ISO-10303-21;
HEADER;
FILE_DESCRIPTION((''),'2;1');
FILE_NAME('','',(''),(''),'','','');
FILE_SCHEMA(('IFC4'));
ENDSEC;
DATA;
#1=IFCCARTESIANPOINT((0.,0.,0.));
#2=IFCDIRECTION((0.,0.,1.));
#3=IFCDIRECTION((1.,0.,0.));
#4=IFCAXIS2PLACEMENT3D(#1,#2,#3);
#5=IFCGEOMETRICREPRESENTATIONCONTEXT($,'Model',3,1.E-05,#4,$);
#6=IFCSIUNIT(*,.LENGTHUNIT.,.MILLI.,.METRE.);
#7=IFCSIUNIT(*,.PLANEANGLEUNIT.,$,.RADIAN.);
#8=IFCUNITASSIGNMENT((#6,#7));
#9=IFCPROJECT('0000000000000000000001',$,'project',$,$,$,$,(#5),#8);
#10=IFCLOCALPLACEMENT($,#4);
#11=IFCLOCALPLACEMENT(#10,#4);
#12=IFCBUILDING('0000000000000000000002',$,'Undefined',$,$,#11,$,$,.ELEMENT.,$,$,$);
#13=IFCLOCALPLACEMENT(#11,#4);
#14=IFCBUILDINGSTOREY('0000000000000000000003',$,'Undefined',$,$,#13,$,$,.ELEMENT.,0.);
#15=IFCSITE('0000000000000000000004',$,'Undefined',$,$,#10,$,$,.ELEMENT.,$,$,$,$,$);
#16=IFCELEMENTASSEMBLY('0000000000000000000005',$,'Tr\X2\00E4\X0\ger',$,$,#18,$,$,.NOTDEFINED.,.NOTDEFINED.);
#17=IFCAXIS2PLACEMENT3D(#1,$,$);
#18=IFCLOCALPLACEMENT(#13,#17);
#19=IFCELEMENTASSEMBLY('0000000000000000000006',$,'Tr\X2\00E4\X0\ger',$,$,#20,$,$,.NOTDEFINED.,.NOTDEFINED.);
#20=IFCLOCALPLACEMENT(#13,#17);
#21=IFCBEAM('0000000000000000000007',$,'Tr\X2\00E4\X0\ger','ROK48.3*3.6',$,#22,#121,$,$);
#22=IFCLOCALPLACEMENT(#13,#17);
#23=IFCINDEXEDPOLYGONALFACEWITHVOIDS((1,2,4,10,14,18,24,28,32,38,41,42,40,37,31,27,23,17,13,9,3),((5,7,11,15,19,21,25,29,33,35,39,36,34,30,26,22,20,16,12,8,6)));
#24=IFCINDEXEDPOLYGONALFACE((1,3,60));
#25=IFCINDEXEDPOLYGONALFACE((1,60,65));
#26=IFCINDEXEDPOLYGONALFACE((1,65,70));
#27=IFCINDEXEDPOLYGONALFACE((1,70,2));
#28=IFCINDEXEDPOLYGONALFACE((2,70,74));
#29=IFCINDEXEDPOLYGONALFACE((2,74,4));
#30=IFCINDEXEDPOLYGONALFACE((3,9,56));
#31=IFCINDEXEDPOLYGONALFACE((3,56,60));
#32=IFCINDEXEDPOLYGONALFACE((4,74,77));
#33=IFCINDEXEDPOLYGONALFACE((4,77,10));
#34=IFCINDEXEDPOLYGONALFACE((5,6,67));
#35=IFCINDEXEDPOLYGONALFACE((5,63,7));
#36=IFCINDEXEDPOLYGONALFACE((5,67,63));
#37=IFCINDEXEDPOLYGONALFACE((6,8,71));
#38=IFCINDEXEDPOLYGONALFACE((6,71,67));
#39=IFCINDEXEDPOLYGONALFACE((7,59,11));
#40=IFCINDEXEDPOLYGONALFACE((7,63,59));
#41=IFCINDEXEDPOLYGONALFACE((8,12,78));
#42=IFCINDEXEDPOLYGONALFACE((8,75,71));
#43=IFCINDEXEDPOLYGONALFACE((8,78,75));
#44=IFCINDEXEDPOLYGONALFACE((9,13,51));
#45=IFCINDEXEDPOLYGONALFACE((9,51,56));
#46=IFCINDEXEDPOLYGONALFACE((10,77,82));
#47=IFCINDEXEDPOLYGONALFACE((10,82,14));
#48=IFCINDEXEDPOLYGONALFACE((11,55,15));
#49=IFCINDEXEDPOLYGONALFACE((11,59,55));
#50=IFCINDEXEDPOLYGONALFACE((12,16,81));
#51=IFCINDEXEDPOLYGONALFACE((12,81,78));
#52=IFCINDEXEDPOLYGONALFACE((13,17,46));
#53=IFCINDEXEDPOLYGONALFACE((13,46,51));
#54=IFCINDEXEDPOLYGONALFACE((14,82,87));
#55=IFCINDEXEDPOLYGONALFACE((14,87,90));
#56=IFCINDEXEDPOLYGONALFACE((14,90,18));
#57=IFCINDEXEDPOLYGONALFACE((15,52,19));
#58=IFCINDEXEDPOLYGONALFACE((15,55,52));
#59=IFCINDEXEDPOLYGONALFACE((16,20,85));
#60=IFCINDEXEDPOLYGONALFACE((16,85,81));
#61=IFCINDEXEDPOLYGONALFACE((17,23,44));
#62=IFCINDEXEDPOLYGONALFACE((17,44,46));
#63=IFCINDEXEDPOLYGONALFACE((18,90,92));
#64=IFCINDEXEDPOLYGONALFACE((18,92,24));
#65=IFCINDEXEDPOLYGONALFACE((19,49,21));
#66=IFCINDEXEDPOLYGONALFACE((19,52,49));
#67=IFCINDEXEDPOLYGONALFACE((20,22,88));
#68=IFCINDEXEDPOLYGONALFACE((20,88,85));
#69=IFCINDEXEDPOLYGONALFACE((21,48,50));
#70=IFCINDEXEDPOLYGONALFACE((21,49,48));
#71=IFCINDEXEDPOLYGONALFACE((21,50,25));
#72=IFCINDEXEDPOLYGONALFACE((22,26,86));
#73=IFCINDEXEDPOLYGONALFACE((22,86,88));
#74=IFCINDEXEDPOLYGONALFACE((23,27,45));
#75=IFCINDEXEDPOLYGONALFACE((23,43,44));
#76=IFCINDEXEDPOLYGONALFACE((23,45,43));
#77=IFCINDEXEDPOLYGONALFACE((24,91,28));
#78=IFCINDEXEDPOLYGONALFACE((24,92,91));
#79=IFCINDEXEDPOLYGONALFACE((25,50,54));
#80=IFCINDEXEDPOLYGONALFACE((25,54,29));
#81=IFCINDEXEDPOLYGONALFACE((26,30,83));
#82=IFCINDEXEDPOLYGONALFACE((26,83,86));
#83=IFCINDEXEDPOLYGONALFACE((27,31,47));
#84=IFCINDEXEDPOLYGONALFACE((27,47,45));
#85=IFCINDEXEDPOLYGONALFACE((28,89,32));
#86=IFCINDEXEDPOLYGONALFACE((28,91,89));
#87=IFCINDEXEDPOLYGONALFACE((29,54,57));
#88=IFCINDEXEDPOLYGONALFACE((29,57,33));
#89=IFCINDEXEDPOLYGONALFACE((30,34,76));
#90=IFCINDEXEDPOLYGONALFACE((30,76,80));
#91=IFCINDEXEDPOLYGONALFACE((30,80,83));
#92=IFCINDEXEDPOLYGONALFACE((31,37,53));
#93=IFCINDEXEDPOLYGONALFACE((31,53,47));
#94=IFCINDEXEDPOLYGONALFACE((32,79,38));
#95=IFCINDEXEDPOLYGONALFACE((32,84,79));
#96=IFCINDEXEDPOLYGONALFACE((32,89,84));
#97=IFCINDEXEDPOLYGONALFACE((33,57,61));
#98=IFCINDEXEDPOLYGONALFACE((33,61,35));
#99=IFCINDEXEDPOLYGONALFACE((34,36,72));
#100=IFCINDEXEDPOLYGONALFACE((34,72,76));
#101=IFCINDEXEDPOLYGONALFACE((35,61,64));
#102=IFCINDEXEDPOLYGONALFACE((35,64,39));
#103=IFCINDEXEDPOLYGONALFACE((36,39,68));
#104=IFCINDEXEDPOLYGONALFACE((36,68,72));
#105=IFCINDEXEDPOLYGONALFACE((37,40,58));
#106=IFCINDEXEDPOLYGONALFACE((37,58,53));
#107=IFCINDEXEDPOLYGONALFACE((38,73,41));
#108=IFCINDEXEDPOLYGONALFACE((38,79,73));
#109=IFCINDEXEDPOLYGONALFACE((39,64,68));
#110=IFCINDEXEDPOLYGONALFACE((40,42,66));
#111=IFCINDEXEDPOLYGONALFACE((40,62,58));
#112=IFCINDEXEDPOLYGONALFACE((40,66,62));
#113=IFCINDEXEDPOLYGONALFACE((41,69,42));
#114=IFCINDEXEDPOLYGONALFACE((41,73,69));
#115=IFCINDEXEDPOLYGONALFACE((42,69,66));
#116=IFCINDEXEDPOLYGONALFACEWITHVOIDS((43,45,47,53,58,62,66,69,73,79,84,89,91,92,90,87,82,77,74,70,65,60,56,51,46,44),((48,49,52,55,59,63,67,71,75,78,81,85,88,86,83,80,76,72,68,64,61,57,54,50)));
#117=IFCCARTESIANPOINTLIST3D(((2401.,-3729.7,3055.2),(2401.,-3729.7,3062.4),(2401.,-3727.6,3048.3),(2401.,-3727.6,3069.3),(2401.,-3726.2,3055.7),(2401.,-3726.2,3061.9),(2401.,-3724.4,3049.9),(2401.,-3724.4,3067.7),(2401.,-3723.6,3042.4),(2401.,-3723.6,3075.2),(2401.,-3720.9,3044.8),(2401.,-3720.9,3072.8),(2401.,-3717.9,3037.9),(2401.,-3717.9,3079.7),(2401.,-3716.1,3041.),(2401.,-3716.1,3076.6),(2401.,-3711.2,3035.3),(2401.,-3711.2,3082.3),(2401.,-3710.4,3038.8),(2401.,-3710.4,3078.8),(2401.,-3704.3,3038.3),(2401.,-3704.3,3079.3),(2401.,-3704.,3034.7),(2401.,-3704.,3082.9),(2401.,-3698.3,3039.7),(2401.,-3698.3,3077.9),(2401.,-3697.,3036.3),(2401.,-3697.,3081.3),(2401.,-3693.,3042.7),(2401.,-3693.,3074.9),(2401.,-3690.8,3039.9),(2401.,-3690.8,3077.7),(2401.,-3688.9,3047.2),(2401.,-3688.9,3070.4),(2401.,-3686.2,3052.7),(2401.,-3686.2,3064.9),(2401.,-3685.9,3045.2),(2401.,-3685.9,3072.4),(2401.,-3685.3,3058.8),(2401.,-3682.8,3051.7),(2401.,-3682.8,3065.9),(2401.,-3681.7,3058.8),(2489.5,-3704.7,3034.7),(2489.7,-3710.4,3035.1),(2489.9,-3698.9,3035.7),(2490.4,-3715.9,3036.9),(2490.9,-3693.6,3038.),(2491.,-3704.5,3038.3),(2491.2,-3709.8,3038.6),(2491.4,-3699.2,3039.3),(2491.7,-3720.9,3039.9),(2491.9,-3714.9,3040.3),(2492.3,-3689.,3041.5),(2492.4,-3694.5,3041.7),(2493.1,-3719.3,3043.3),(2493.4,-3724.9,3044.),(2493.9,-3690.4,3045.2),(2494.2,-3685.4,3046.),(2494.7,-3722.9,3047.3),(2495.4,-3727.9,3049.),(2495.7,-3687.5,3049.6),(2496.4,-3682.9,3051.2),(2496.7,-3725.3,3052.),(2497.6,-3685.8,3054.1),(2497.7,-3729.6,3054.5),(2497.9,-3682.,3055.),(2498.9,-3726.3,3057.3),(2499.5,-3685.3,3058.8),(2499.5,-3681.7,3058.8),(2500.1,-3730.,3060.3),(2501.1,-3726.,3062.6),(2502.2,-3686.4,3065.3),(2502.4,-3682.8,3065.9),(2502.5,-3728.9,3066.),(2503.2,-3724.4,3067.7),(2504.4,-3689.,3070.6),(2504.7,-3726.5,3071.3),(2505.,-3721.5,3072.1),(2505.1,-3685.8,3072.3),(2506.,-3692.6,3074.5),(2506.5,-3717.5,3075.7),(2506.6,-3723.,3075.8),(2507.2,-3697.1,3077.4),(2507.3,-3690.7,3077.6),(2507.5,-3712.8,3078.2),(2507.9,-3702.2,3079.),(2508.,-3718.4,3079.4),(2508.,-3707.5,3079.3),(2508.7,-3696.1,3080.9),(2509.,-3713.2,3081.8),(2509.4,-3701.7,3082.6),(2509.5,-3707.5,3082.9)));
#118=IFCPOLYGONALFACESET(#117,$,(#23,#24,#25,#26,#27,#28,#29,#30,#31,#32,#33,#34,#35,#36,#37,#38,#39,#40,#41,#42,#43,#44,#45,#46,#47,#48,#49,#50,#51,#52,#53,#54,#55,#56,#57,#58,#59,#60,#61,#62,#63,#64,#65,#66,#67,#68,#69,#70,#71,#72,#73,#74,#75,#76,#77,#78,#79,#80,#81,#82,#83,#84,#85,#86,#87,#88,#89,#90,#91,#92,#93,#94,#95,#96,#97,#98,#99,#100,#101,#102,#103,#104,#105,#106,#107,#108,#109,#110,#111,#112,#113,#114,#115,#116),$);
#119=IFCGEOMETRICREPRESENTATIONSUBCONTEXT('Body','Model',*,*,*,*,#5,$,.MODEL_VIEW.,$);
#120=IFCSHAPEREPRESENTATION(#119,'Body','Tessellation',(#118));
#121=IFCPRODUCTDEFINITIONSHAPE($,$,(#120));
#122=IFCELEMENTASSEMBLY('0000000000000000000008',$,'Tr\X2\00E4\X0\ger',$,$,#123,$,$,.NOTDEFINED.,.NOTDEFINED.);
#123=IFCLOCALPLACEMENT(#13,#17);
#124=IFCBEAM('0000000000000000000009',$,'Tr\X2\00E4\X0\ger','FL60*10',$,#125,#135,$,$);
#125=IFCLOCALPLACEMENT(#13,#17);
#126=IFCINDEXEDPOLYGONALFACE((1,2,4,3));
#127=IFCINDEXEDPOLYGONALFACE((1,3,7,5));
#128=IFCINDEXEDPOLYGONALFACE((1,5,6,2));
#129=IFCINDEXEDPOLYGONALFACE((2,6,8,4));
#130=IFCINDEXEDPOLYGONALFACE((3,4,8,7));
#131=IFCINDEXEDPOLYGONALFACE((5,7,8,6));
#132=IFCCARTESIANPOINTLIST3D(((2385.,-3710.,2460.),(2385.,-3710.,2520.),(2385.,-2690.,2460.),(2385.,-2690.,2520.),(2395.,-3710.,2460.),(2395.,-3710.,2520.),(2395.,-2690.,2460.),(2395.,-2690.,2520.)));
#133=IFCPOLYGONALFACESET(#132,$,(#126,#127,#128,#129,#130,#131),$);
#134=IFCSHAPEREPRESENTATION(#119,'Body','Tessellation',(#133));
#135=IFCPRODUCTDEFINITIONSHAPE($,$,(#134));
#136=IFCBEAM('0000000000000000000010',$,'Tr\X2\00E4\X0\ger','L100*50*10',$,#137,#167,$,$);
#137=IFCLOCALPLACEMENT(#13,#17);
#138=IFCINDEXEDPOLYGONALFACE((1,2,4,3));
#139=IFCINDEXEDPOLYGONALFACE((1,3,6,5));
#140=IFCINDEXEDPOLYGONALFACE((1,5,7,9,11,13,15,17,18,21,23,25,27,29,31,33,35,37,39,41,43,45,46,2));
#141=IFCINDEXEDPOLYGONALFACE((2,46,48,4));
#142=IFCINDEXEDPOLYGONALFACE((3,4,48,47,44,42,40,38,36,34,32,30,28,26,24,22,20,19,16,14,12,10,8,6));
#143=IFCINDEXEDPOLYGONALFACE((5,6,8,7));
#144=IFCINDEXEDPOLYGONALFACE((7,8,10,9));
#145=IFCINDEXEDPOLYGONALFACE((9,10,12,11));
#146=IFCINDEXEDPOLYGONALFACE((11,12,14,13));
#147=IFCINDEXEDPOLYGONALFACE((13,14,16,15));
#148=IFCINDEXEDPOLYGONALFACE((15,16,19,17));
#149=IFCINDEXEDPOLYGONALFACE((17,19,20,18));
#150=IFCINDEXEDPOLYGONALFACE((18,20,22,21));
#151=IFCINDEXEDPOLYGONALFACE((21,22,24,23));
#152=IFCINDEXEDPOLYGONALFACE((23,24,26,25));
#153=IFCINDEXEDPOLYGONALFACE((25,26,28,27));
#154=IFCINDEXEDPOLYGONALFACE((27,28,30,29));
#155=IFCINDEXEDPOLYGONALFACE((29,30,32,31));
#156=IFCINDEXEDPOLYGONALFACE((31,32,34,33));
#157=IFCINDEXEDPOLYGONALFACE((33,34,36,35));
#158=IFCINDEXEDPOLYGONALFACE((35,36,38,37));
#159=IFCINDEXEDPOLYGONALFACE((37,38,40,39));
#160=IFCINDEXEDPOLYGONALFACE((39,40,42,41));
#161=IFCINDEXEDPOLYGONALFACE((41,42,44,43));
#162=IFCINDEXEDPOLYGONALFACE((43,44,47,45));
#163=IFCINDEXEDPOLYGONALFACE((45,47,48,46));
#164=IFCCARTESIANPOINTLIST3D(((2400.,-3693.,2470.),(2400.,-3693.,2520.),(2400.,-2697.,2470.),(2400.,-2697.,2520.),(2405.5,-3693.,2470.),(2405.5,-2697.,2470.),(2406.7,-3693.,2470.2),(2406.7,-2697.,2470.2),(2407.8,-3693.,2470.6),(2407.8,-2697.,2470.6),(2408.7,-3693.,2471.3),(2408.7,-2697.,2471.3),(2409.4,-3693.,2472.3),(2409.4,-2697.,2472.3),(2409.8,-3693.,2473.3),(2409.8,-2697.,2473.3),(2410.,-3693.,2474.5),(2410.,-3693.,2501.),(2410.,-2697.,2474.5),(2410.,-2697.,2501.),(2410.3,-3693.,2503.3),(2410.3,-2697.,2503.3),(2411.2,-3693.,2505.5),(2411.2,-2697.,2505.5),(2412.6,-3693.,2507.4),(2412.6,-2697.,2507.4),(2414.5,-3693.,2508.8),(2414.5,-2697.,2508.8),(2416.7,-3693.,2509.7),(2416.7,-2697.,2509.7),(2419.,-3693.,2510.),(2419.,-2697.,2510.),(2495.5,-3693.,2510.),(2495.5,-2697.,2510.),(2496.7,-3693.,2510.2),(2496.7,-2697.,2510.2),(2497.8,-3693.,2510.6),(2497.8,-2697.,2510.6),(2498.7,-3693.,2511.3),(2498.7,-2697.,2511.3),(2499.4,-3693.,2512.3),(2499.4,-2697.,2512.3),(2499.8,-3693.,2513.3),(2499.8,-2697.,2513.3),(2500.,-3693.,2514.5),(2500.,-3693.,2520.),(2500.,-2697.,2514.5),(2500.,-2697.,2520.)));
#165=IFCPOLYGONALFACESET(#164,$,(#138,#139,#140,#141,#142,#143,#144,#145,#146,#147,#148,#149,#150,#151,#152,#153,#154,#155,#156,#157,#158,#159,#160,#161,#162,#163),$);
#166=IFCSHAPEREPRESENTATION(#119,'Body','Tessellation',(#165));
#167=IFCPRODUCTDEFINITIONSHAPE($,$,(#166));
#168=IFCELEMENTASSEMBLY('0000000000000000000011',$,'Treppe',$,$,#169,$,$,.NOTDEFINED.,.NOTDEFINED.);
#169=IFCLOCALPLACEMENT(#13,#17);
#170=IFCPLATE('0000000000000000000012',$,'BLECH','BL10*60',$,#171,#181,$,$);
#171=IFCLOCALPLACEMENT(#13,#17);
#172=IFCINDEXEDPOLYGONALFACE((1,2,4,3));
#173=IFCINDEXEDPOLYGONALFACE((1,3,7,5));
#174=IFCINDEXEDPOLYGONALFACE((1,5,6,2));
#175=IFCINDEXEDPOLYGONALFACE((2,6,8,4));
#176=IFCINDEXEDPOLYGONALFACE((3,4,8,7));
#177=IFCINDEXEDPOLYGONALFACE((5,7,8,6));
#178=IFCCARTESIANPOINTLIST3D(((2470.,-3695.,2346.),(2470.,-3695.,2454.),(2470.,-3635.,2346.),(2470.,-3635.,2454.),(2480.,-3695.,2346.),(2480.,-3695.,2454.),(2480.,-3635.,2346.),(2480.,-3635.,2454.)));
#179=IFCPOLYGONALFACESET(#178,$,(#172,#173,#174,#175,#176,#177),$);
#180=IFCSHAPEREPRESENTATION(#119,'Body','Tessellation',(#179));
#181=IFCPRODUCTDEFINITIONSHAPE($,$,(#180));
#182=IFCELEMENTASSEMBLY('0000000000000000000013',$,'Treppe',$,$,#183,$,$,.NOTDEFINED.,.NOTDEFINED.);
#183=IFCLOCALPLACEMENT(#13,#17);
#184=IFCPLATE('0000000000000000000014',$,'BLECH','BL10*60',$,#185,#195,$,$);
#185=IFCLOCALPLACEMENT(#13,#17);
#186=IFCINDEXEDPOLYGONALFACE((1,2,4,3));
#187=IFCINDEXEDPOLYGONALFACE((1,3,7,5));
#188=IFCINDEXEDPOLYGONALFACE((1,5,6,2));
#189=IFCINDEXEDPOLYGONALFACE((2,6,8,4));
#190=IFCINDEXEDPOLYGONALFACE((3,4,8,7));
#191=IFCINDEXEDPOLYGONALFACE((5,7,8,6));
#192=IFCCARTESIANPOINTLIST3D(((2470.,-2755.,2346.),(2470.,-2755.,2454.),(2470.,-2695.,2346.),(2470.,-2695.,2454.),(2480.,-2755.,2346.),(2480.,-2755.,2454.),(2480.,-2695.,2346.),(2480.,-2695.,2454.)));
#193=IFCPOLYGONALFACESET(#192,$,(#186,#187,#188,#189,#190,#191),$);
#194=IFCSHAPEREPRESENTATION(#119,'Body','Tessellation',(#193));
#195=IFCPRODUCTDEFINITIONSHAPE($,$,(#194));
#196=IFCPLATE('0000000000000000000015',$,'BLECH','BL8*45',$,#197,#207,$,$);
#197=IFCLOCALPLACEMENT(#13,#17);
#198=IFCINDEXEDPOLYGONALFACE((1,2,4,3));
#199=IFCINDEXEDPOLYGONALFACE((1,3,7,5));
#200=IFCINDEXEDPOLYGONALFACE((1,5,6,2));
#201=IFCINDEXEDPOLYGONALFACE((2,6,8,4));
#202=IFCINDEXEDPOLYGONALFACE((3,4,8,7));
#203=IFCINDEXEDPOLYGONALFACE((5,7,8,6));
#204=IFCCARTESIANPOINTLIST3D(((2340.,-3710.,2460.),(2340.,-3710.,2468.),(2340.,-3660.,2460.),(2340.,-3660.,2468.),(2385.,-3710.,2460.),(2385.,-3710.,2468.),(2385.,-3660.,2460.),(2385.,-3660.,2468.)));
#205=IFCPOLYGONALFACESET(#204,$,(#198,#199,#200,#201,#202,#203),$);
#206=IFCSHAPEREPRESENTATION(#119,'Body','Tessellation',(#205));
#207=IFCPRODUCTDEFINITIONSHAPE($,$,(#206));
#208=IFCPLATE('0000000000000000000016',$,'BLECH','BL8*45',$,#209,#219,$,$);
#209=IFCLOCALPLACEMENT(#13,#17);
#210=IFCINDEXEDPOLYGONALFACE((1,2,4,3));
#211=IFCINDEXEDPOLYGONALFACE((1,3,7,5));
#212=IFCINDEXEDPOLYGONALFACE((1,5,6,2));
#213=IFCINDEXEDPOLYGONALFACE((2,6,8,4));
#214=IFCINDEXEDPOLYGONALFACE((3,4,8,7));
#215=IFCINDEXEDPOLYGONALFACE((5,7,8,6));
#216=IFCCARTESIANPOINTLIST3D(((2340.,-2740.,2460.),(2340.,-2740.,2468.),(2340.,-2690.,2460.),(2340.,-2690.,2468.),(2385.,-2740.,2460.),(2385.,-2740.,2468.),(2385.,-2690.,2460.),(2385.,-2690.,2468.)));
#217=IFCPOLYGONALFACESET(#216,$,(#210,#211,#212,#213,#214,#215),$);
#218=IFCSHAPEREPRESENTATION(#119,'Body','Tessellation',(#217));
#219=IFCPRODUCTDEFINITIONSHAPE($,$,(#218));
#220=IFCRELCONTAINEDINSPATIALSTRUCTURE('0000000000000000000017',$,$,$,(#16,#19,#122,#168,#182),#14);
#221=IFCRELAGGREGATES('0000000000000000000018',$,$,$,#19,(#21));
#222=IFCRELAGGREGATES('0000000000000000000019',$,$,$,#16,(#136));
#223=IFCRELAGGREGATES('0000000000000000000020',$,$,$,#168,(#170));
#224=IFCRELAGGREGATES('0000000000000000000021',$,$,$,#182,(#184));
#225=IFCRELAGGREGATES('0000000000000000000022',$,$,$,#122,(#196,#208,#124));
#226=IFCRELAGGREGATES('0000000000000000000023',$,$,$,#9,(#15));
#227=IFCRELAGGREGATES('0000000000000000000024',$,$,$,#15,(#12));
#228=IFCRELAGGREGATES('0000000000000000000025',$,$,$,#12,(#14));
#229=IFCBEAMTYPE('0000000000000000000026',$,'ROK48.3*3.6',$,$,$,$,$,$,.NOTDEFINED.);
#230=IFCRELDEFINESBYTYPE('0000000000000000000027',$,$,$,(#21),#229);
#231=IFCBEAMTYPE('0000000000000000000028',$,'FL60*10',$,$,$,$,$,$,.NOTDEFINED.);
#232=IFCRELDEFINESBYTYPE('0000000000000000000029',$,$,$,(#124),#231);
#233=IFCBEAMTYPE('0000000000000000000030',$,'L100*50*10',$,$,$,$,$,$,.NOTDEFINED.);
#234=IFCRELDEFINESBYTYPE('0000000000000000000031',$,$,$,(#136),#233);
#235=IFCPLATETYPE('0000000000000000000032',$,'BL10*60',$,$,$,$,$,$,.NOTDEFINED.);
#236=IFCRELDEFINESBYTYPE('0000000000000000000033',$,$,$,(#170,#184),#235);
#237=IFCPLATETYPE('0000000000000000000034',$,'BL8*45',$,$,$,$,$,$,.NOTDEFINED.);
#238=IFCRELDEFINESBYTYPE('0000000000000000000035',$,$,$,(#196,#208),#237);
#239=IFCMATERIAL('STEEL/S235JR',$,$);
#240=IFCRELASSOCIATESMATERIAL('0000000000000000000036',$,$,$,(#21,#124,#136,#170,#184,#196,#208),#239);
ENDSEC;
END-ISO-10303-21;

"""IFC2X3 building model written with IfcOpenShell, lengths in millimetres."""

from ifc_helpers import new_model, si_unit, frame, origin_with_axes, origin_2d_with_axis, place, context, subcontext, project, spatial, polyline, rectangle, hollow_circle, l_section, outline, extrude, clip, halfspace, material, type_object, element, aggregate, save


model = new_model("IFC2X3")

# Units and contexts
model_context = context("Model", 3, precision=1e-05, world=origin_with_axes())
body_context = subcontext(model_context, "Body", "Model", "MODEL_VIEW")
ifc_project = project(units=[si_unit("LENGTHUNIT", "METRE", prefix="MILLI"), si_unit("PLANEANGLEUNIT", "RADIAN")], contexts=[model_context])

# Site, building, storey
site_placement = place(None, origin_with_axes())
site = spatial("IfcSite", under=ifc_project, at=site_placement, Name="Undefined", CompositionType="ELEMENT")
building_placement = place(site_placement, origin_with_axes())
building = spatial("IfcBuilding", under=site, at=building_placement, Name="Undefined", CompositionType="ELEMENT")
storey_placement = place(building_placement, origin_with_axes())
storey = spatial("IfcBuildingStorey", under=building, at=storey_placement, Name="Undefined", CompositionType="ELEMENT", Elevation=0.0)

# Element assembly
assembly_1_placement = place(storey_placement, origin_with_axes())
assembly_1 = element("IfcElementAssembly", 1, at=assembly_1_placement, inside=storey, Name="Träger", AssemblyPlace="NOTDEFINED", PredefinedType="NOTDEFINED")
ifc_material = material(Name="STEEL/S235JR")

# Element assemblies, beams
beam_type_1 = type_object("IfcBeamType", Name="ROK48.3*3.6", PredefinedType="NOTDEFINED")
assembly_2_placement = place(storey_placement, origin_with_axes())
assembly_2 = element("IfcElementAssembly", 2, at=assembly_2_placement, inside=storey, Name="Träger", AssemblyPlace="NOTDEFINED", PredefinedType="NOTDEFINED")
beam_1_placement = place(assembly_2_placement, frame((2500.0, -3705.9, 3058.8), z_axis=(0.0, 0.0, 1.0), x_axis=(-1.0, 0.0, 0.0)))
beam_1 = element("IfcBeam", 3, at=beam_1_placement, type_object=beam_type_1, material=ifc_material, Name="Träger", Description="ROK48.3*3.6", context=body_context, shape_type="Clipping", body=[
    clip(extrude(hollow_circle(Radius=24.1, WallThickness=3.6, at=origin_2d_with_axis()), frame((99.0, 0.0, 0.0), z_axis=(-1.0, 0.0, 0.0), x_axis=(0.0, -1.0, 0.0)), (0.0, 0.0, 1.0), 108.6), halfspace(frame((-9.5, 0.0, 24.2), z_axis=(-0.923878, 0.0, -0.382686), x_axis=(0.0, -1.0, 0.0)), False)),
])
aggregate(assembly_2, [beam_1])
assembly_3_placement = place(storey_placement, origin_with_axes())
assembly_3 = element("IfcElementAssembly", 4, at=assembly_3_placement, inside=storey, Name="Träger", AssemblyPlace="NOTDEFINED", PredefinedType="NOTDEFINED")
beam_type_2 = type_object("IfcBeamType", Name="FL60*10", PredefinedType="NOTDEFINED")
beam_2_placement = place(assembly_3_placement, frame((2390.0, -2690.0, 2490.0), z_axis=(0.0, 0.0, 1.0), x_axis=(0.0, -1.0, 0.0)))
beam_2 = element("IfcBeam", 5, at=beam_2_placement, type_object=beam_type_2, material=ifc_material, Name="Träger", Description="FL60*10", context=body_context, shape_type="SweptSolid", body=[
    extrude(rectangle(XDim=10.0, YDim=60.0, at=origin_2d_with_axis()), frame((1020.0, 0.0, 0.0), z_axis=(-1.0, 0.0, 0.0), x_axis=(0.0, -1.0, 0.0)), (0.0, 0.0, 1.0), 1020.0),
])

# Beam
beam_type_3 = type_object("IfcBeamType", Name="L100*50*10", PredefinedType="NOTDEFINED")
beam_3_placement = place(assembly_1_placement, frame((2450.0, -3693.0, 2495.0), z_axis=(1.0, 0.0, 0.0), x_axis=(0.0, 1.0, 0.0)))
beam_3 = element("IfcBeam", 6, at=beam_3_placement, type_object=beam_type_3, material=ifc_material, Name="Träger", Description="L100*50*10", context=body_context, shape_type="SweptSolid", body=[
    extrude(l_section(Depth=100.0, Width=50.0, Thickness=10.0, FilletRadius=9.0, EdgeRadius=4.5, at=origin_2d_with_axis()), frame((996.0, 0.0, 0.0), z_axis=(-1.0, 0.0, 0.0), x_axis=(0.0, -1.0, 0.0)), (0.0, 0.0, 1.0), 996.0),
])
aggregate(assembly_1, [beam_3])

# Element assemblies, plates
assembly_4_placement = place(storey_placement, origin_with_axes())
assembly_4 = element("IfcElementAssembly", 7, at=assembly_4_placement, inside=storey, Name="Treppe", AssemblyPlace="NOTDEFINED", PredefinedType="NOTDEFINED")
plate_type_1 = type_object("IfcPlateType", Name="BL10*60", PredefinedType="NOTDEFINED")
plate_1_placement = place(assembly_4_placement, frame((2475.0, -3695.0, 2454.0), z_axis=(-1.0, 0.0, 0.0), x_axis=(0.0, 1.0, 0.0)))
plate_1 = element("IfcPlate", 8, at=plate_1_placement, type_object=plate_type_1, material=ifc_material, Name="BLECH", Description="BL10*60", context=body_context, shape_type="SweptSolid", body=[
    extrude(outline(polyline([(0.0, 0.0), (60.0, 0.0), (60.0, 108.0), (0.0, 108.0), (0.0, 0.0)])), frame((0.0, 0.0, -5.0), z_axis=(0.0, 0.0, 1.0), x_axis=(1.0, 0.0, 0.0)), (0.0, 0.0, 1.0), 10.0),
])
aggregate(assembly_4, [plate_1])
assembly_5_placement = place(storey_placement, origin_with_axes())
assembly_5 = element("IfcElementAssembly", 9, at=assembly_5_placement, inside=storey, Name="Treppe", AssemblyPlace="NOTDEFINED", PredefinedType="NOTDEFINED")
plate_2_placement = place(assembly_5_placement, frame((2475.0, -2695.0, 2454.0), z_axis=(1.0, 0.0, 0.0), x_axis=(0.0, -1.0, 0.0)))
plate_2 = element("IfcPlate", 10, at=plate_2_placement, type_object=plate_type_1, material=ifc_material, Name="BLECH", Description="BL10*60", context=body_context, shape_type="SweptSolid", body=[
    extrude(outline(polyline([(0.0, 0.0), (60.0, 0.0), (60.0, 108.0), (0.0, 108.0), (0.0, 0.0)])), frame((0.0, 0.0, -5.0), z_axis=(0.0, 0.0, 1.0), x_axis=(1.0, 0.0, 0.0)), (0.0, 0.0, 1.0), 10.0),
])
aggregate(assembly_5, [plate_2])

# Plates
plate_type_2 = type_object("IfcPlateType", Name="BL8*45", PredefinedType="NOTDEFINED")
plate_3_placement = place(assembly_3_placement, frame((2340.0, -3660.0, 2464.0), z_axis=(0.0, 0.0, -1.0), x_axis=(1.0, 0.0, 0.0)))
plate_3 = element("IfcPlate", 11, at=plate_3_placement, type_object=plate_type_2, material=ifc_material, Name="BLECH", Description="BL8*45", context=body_context, shape_type="SweptSolid", body=[
    extrude(outline(polyline([(0.0, 0.0), (45.0, 0.0), (45.0, 50.0), (0.0, 50.0), (0.0, 0.0)])), frame((0.0, 0.0, -4.0), z_axis=(0.0, 0.0, 1.0), x_axis=(1.0, 0.0, 0.0)), (0.0, 0.0, 1.0), 8.0),
])
plate_4_placement = place(assembly_3_placement, frame((2340.0, -2740.0, 2464.0), z_axis=(0.0, 0.0, 1.0), x_axis=(1.0, 0.0, 0.0)))
plate_4 = element("IfcPlate", 12, at=plate_4_placement, type_object=plate_type_2, material=ifc_material, Name="BLECH", Description="BL8*45", context=body_context, shape_type="SweptSolid", body=[
    extrude(outline(polyline([(0.0, 0.0), (45.0, 0.0), (45.0, 50.0), (0.0, 50.0), (0.0, 0.0)])), frame((0.0, 0.0, -4.0), z_axis=(0.0, 0.0, 1.0), x_axis=(1.0, 0.0, 0.0)), (0.0, 0.0, 1.0), 8.0),
])
aggregate(assembly_3, [plate_3, plate_4, beam_2])

save(model, "model.ifc")
